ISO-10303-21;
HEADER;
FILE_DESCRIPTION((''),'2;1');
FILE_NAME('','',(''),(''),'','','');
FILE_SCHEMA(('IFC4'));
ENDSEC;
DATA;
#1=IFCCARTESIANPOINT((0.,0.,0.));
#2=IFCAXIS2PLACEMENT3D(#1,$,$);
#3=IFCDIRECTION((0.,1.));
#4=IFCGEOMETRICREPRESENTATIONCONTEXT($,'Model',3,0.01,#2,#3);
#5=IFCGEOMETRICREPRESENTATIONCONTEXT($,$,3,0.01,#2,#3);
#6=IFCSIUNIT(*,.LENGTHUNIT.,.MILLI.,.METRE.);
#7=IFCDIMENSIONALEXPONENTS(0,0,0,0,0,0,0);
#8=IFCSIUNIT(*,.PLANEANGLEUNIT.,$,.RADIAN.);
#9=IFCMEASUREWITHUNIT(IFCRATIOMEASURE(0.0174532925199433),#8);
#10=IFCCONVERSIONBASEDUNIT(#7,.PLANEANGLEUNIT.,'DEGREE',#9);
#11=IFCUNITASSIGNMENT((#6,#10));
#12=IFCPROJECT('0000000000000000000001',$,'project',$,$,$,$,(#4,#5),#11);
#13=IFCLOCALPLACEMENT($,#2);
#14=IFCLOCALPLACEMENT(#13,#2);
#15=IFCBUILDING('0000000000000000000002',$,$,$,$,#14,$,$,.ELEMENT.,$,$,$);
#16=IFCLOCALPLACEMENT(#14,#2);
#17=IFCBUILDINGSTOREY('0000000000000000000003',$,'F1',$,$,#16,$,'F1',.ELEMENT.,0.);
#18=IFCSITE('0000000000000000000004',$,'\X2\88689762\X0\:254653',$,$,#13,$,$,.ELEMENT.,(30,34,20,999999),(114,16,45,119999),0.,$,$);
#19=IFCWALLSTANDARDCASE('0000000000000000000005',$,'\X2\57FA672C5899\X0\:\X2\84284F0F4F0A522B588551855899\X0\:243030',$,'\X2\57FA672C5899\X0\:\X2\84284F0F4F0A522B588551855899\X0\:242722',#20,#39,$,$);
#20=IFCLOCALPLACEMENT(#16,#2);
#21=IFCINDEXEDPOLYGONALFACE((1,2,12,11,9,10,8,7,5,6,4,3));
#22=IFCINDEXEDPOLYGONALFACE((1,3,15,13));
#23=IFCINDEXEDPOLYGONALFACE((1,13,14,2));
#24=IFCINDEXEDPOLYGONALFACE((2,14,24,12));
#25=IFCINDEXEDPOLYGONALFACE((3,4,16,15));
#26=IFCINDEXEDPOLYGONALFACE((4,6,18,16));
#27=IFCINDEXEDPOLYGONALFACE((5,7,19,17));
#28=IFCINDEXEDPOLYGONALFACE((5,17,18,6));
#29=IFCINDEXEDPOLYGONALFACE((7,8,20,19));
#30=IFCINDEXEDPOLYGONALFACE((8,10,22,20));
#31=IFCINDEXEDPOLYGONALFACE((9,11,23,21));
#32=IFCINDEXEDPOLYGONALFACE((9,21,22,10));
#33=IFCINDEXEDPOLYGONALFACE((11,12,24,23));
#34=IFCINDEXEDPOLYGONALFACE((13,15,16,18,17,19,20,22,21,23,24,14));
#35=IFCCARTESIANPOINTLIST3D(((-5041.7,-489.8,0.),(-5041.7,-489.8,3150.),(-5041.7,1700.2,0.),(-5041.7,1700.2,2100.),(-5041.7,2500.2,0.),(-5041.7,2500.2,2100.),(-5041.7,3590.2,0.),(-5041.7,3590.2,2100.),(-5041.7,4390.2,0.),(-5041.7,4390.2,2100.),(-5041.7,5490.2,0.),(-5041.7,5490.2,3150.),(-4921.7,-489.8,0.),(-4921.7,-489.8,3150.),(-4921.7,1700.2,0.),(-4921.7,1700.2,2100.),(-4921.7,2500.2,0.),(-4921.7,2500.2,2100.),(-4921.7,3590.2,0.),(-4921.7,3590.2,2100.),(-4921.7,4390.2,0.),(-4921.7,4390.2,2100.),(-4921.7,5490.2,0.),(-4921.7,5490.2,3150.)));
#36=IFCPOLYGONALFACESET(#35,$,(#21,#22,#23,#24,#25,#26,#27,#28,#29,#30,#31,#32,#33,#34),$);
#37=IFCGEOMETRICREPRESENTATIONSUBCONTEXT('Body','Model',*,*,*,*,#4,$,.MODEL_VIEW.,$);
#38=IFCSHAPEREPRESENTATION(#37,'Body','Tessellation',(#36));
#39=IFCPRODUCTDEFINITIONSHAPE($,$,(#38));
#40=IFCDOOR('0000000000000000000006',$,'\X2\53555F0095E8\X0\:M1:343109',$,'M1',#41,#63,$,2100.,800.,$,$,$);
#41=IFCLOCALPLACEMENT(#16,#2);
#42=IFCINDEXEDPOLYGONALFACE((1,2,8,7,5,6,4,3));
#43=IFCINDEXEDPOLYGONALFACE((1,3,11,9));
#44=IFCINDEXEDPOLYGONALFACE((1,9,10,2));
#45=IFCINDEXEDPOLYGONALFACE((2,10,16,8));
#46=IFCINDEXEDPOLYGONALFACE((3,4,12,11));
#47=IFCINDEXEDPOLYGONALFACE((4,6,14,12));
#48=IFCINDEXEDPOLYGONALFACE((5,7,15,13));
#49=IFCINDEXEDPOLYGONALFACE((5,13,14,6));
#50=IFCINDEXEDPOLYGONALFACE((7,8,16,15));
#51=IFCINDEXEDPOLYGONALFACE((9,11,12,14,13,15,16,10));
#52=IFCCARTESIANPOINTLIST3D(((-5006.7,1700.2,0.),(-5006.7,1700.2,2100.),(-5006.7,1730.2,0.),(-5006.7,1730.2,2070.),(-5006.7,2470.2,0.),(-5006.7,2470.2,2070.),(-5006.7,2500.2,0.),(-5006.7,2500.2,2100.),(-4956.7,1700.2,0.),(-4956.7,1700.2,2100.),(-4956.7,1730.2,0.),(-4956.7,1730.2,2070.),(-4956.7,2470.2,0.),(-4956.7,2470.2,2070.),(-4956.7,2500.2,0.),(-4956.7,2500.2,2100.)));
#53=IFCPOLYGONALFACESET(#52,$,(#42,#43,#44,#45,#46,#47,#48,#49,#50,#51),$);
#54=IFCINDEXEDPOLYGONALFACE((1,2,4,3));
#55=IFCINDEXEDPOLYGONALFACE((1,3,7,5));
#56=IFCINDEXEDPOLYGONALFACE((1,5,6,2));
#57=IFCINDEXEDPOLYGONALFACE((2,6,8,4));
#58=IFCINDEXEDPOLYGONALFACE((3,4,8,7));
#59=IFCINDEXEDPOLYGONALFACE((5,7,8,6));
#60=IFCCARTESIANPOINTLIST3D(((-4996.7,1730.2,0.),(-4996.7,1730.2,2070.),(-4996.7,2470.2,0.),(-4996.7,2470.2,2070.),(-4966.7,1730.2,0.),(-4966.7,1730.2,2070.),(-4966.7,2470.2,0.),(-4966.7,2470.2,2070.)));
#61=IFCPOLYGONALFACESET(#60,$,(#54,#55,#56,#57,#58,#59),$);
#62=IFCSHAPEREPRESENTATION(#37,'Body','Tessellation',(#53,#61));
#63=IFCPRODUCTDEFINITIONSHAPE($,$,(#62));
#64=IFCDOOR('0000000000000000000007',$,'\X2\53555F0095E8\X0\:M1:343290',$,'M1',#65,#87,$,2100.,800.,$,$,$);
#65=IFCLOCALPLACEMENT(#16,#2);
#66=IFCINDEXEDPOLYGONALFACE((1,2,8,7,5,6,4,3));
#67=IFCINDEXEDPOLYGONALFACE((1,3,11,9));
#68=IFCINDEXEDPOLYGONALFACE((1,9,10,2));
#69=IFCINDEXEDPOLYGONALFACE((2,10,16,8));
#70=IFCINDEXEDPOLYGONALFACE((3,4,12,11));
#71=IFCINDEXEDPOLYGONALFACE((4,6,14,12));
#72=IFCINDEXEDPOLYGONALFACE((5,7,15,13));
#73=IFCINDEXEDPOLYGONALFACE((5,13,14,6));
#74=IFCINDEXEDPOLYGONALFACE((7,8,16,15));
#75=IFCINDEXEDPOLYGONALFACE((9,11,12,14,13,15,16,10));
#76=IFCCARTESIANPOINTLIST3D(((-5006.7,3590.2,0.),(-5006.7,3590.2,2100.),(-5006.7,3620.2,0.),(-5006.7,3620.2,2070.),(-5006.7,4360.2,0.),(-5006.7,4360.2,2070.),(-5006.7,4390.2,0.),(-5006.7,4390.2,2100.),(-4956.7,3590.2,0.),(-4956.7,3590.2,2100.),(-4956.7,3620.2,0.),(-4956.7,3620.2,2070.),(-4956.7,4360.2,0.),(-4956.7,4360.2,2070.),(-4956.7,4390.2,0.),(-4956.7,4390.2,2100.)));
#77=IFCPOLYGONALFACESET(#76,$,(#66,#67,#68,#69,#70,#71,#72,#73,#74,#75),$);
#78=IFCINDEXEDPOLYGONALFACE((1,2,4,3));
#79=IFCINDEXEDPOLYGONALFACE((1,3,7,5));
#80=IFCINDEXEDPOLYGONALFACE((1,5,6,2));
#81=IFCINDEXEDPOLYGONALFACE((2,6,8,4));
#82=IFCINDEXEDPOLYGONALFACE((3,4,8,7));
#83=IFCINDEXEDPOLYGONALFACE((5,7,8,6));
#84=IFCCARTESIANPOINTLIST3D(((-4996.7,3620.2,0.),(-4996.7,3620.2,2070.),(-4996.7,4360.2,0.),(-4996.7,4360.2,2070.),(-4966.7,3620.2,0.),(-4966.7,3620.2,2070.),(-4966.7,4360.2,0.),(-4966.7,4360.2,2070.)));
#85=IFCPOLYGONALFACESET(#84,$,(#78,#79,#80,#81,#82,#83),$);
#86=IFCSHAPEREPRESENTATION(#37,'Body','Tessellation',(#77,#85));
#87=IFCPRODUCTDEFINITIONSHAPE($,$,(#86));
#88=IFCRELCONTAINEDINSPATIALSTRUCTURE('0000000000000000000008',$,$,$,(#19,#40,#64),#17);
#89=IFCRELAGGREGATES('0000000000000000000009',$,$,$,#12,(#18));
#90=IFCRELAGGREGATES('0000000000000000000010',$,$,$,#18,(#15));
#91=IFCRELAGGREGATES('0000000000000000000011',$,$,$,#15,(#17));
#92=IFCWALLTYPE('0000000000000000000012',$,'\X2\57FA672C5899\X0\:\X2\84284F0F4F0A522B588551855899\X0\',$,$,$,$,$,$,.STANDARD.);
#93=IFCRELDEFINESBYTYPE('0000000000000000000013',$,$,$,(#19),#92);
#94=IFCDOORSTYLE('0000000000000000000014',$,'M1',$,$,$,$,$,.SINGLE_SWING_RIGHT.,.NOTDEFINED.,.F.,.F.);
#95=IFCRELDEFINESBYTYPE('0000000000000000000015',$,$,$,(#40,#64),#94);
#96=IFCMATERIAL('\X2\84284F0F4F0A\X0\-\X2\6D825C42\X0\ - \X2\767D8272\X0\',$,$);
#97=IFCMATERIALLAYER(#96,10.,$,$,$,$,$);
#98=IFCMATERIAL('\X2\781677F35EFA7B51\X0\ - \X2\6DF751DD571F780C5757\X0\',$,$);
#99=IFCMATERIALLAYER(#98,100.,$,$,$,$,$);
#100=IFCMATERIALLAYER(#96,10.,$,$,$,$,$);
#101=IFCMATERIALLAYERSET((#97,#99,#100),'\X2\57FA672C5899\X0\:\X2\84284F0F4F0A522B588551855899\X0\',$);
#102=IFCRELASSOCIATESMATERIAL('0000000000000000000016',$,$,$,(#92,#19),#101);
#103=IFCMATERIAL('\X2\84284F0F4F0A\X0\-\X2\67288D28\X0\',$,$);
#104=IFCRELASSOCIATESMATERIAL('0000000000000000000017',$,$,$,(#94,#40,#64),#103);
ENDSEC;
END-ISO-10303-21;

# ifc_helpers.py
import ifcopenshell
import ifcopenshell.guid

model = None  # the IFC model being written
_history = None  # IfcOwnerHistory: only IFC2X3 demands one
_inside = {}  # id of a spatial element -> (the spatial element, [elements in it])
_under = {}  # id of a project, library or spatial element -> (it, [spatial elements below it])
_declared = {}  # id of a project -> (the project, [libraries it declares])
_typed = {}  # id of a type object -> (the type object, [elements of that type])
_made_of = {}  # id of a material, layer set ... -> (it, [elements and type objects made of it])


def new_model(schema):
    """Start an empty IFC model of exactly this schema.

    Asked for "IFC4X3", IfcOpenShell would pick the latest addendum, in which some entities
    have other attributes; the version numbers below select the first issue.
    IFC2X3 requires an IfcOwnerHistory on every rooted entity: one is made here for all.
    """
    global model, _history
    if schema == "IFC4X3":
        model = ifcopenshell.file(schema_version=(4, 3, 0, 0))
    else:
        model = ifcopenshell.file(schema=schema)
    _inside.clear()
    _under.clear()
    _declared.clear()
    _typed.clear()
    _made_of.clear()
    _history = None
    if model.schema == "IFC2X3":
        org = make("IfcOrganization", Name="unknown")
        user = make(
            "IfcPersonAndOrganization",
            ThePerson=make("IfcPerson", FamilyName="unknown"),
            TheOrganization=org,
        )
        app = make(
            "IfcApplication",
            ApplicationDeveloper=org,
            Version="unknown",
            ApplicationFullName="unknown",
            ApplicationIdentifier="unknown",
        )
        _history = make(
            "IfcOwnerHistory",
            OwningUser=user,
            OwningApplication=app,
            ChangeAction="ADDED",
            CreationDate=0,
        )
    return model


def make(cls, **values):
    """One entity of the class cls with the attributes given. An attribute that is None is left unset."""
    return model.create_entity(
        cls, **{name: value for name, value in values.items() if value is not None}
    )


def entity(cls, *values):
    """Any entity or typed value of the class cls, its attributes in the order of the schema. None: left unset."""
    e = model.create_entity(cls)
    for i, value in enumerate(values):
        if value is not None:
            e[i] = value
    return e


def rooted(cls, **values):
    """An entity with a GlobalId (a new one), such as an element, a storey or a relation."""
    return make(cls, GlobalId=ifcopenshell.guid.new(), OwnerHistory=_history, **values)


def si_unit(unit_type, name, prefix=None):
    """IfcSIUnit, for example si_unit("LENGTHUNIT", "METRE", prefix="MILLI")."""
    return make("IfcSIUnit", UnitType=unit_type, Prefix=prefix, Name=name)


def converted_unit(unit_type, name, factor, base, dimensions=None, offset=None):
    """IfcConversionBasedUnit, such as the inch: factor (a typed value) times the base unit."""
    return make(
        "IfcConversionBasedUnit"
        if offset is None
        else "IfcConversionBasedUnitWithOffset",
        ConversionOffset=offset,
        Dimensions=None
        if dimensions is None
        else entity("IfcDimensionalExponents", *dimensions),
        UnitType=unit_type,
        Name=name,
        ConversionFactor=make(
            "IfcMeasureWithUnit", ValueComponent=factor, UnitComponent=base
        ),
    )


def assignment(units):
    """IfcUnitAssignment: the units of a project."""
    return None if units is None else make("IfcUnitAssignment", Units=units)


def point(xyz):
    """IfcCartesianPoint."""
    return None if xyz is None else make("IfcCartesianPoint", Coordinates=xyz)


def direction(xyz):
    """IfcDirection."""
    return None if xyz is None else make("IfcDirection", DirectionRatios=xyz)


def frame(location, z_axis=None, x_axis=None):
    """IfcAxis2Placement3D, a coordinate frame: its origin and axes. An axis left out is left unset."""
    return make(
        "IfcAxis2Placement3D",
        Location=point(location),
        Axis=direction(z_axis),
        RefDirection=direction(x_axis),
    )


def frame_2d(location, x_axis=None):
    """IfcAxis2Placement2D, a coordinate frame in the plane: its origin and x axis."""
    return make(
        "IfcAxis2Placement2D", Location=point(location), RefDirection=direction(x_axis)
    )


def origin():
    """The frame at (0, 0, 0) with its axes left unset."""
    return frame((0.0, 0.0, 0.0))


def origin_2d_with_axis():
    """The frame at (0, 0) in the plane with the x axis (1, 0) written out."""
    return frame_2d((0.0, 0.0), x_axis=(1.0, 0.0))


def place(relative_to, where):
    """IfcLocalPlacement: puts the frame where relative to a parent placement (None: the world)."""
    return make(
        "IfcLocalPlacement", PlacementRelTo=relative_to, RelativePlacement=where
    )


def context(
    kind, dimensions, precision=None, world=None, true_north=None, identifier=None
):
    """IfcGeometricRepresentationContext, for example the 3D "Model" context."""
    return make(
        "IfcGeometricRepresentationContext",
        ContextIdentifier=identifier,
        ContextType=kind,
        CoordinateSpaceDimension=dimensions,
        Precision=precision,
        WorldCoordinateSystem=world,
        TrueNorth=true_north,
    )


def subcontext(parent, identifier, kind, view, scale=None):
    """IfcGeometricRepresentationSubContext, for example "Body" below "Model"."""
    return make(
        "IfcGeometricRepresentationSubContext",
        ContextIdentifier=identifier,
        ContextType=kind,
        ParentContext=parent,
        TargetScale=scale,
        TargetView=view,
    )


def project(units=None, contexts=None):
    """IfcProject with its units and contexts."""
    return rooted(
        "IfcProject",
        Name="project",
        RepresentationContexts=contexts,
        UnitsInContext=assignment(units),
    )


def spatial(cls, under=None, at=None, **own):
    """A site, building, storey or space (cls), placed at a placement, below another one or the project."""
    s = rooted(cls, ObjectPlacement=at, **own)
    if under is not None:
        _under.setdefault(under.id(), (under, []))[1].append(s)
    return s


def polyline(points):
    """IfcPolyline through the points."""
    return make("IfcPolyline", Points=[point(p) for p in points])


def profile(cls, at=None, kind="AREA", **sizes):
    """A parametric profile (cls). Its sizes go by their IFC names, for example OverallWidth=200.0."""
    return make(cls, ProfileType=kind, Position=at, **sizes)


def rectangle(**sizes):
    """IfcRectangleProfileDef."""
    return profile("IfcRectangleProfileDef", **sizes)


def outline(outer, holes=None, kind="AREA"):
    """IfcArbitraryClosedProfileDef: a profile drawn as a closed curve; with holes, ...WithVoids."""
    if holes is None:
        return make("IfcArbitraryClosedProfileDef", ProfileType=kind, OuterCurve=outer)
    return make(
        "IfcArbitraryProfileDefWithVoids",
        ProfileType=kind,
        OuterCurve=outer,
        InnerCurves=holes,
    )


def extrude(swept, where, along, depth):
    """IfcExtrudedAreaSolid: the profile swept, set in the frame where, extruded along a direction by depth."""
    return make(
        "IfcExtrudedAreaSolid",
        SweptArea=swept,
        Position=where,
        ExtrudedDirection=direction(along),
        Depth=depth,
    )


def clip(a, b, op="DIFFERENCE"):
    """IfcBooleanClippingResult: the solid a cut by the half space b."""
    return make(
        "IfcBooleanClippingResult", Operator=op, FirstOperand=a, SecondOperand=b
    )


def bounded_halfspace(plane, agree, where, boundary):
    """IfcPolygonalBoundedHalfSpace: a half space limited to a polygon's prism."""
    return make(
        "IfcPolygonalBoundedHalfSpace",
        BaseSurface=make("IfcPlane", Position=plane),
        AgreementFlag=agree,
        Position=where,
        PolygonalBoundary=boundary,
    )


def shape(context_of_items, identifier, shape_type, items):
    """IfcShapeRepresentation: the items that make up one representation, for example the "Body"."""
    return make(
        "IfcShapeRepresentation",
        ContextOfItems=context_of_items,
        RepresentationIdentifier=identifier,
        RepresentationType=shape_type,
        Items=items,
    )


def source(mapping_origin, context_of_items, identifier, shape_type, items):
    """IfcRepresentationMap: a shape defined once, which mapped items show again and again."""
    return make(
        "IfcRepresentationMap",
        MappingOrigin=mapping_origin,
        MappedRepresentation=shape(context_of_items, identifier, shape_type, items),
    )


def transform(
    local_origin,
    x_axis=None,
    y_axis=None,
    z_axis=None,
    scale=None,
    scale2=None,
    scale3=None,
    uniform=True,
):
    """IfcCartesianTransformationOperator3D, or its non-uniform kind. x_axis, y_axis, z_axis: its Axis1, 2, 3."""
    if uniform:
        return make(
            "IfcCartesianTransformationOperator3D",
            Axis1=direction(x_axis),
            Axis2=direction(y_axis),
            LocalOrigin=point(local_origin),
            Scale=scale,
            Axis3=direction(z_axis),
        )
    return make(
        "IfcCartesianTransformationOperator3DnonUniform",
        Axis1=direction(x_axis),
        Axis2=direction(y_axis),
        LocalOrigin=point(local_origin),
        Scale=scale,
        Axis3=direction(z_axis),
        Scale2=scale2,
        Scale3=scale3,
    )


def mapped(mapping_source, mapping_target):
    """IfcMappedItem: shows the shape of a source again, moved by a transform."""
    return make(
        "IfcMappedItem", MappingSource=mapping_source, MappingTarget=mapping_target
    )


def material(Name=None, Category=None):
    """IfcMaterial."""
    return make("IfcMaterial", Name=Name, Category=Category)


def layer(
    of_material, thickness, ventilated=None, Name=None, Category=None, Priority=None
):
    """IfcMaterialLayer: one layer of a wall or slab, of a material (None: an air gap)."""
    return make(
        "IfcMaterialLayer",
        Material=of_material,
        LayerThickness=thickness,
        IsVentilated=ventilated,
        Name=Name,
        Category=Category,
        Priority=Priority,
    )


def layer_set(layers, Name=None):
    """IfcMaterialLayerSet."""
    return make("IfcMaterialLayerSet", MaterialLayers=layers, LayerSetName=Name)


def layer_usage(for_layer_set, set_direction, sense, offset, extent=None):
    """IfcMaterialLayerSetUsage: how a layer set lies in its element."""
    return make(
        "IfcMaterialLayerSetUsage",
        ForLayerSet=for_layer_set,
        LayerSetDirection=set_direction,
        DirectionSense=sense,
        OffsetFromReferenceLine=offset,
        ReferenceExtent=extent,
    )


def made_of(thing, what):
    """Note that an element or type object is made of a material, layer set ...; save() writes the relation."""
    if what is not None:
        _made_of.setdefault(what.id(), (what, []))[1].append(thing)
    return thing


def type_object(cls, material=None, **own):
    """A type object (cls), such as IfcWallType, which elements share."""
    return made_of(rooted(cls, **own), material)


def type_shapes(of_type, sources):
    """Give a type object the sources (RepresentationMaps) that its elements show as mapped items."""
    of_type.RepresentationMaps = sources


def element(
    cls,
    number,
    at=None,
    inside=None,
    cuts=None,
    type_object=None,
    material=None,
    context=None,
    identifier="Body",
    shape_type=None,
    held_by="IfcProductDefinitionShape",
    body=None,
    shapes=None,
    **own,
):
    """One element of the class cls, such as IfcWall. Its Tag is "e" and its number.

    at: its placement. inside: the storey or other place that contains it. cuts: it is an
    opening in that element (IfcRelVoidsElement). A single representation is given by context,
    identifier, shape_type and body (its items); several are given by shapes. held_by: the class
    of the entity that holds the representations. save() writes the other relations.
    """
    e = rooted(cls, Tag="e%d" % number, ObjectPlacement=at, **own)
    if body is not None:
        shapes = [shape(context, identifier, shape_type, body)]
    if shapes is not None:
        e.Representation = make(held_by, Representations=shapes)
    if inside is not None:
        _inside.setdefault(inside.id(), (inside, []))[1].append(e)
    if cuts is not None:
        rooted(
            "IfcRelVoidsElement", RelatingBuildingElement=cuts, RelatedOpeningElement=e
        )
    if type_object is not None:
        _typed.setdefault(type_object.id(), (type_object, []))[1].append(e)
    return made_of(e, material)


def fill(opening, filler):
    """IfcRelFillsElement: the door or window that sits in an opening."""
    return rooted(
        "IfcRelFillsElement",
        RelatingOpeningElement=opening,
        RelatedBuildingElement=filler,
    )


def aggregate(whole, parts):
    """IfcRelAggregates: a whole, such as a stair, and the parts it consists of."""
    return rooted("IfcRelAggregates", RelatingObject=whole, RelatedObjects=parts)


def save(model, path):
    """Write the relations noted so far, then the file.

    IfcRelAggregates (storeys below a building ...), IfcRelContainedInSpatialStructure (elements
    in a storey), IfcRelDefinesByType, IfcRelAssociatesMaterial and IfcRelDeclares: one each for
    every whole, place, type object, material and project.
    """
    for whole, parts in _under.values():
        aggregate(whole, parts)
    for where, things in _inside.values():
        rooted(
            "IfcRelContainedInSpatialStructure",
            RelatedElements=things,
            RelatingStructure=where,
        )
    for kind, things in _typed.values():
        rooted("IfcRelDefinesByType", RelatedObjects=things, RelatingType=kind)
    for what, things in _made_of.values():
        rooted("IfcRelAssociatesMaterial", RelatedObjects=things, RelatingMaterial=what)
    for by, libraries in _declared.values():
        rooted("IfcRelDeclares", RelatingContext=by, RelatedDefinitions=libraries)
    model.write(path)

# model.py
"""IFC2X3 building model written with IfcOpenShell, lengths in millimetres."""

from ifc_helpers import new_model, entity, si_unit, converted_unit, direction, frame, frame_2d, origin, origin_2d_with_axis, place, context, subcontext, project, spatial, polyline, rectangle, outline, extrude, clip, bounded_halfspace, source, transform, mapped, material, layer, layer_set, layer_usage, type_object, type_shapes, element, fill, save


model = new_model("IFC2X3")

# Units and contexts
model_context = context("Model", 3, precision=0.01, world=origin(), true_north=direction((0.0, 1.0)))
context_of_model = context(None, 3, precision=0.01, world=origin(), true_north=direction((0.0, 1.0)))
body_context = subcontext(model_context, "Body", "Model", "MODEL_VIEW")
ifc_project = project(units=[si_unit("LENGTHUNIT", "METRE", prefix="MILLI"), converted_unit("PLANEANGLEUNIT", "DEGREE", entity("IfcRatioMeasure", 0.0174532925199433), si_unit("PLANEANGLEUNIT", "RADIAN"), dimensions=[0, 0, 0, 0, 0, 0, 0])], contexts=[model_context, context_of_model])

# Site, building, storey
site_placement = place(None, origin())
site = spatial("IfcSite", under=ifc_project, at=site_placement, Name="表面:254653", CompositionType="ELEMENT", RefLatitude=(30, 34, 20, 999999), RefLongitude=(114, 16, 45, 119999), RefElevation=0.0)
building_placement = place(site_placement, origin())
building = spatial("IfcBuilding", under=site, at=building_placement, CompositionType="ELEMENT")
storey_placement = place(building_placement, origin())
storey = spatial("IfcBuildingStorey", under=building, at=storey_placement, Name="F1", LongName="F1", CompositionType="ELEMENT", Elevation=0.0)

# Wall, openings, doors
ifc_material_1 = material(Name="萨伏伊-涂层 - 白色")
ifc_layer_1 = layer(ifc_material_1, 10.0)
ifc_material_2 = material(Name="砖石建筑 - 混凝土砌块")
ifc_layer_2 = layer(ifc_material_2, 100.0)
ifc_layer_3 = layer(ifc_material_1, 10.0)
ifc_layer_set_1 = layer_set([ifc_layer_1, ifc_layer_2, ifc_layer_3], Name="基本墙:萨伏伊别墅内墙")
ifc_layer_usage_1 = layer_usage(ifc_layer_set_1, "AXIS2", "NEGATIVE", 60.0)
wall_type_1 = type_object("IfcWallType", Name="基本墙:萨伏伊别墅内墙", PredefinedType="STANDARD", material=ifc_layer_set_1)
wall_1_placement = place(storey_placement, frame((-4981.7, -489.8, 0.0), z_axis=(0.0, 0.0, 1.0), x_axis=(0.0, 1.0, 0.0)))
wall_1 = element("IfcWallStandardCase", 1, at=wall_1_placement, inside=storey, type_object=wall_type_1, material=ifc_layer_usage_1, Name="基本墙:萨伏伊别墅内墙:243030", ObjectType="基本墙:萨伏伊别墅内墙:242722", context=body_context, shape_type="Clipping", body=[
    clip(extrude(rectangle(XDim=5980.0, YDim=120.0, at=frame_2d((2990.0, 0.0), x_axis=(-1.0, 0.0))), origin(), (0.0, 0.0, 1.0), 3150.0), bounded_halfspace(frame((0.0, -60.0, 3150.0), z_axis=(0.0, 0.0, -1.0), x_axis=(-1.0, 0.0, 0.0)), True, frame((0.0, -60.0, 3150.0)), polyline([(0.0, 0.0), (5980.0, 0.0), (5980.0, 120.0), (3310.0, 120.0), (3190.0, 120.0), (0.0, 120.0), (0.0, 0.0)]))),
])
opening_1_placement = place(wall_1_placement, frame((2190.0, -60.0, 0.0)))
opening_1 = element("IfcOpeningElement", 2, at=opening_1_placement, cuts=wall_1, ObjectType="Opening", context=body_context, shape_type="SweptSolid", body=[
    extrude(rectangle(XDim=2100.0, YDim=800.0, at=frame_2d((1050.0, 400.0), x_axis=(1.0, 0.0))), frame((0.0, 0.0, 0.0), z_axis=(0.0, 1.0, 0.0), x_axis=(0.0, 0.0, 1.0)), (0.0, 0.0, 1.0), 120.0),
])
opening_2_placement = place(wall_1_placement, frame((4080.0, -60.0, 0.0)))
opening_2 = element("IfcOpeningElement", 3, at=opening_2_placement, cuts=wall_1, ObjectType="Opening", context=body_context, shape_type="SweptSolid", body=[
    extrude(rectangle(XDim=2100.0, YDim=800.0, at=frame_2d((1050.0, 400.0), x_axis=(1.0, 0.0))), frame((0.0, 0.0, 0.0), z_axis=(0.0, 1.0, 0.0), x_axis=(0.0, 0.0, 1.0)), (0.0, 0.0, 1.0), 120.0),
])
ifc_material_3 = material(Name="萨伏伊-木质")
door_style = type_object("IfcDoorStyle", Name="M1", ConstructionType="NOTDEFINED", OperationType="SINGLE_SWING_RIGHT", ParameterTakesPrecedence=False, Sizeable=False, material=ifc_material_3)
shared_shape = source(origin(), body_context, "Body", "SweptSolid", [
    extrude(outline(polyline([(-1057.5, -400.0), (1042.5, -400.0), (1042.5, -370.0), (-1027.5, -370.0), (-1027.5, 370.0), (1042.5, 370.0), (1042.5, 400.0), (-1057.5, 400.0), (-1057.5, -400.0)])), frame((400.0, 85.0, 1042.5), z_axis=(0.0, -1.0, 0.0), x_axis=(0.0, 0.0, -1.0)), (0.0, 0.0, 1.0), 50.0),
    extrude(rectangle(XDim=740.0, YDim=30.0, at=origin_2d_with_axis()), frame((400.0, 60.0, 0.0)), (0.0, 0.0, 1.0), 2070.0),
])
type_shapes(door_style, [shared_shape])
door_1_placement = place(opening_1_placement, origin())
door_1 = element("IfcDoor", 4, at=door_1_placement, inside=storey, type_object=door_style, material=ifc_material_3, Name="单开门:M1:343109", ObjectType="M1", OverallHeight=2100.0, OverallWidth=800.0, context=body_context, shape_type="MappedRepresentation", body=[
    mapped(shared_shape, transform((0.0, 0.0, 0.0), scale=1.0)),
])
fill(opening_1, door_1)
door_2_placement = place(opening_2_placement, origin())
door_2 = element("IfcDoor", 5, at=door_2_placement, inside=storey, type_object=door_style, material=ifc_material_3, Name="单开门:M1:343290", ObjectType="M1", OverallHeight=2100.0, OverallWidth=800.0, context=body_context, shape_type="MappedRepresentation", body=[
    mapped(shared_shape, transform((0.0, 0.0, 0.0), scale=1.0)),
])
fill(opening_2, door_2)

save(model, "model.ifc")
